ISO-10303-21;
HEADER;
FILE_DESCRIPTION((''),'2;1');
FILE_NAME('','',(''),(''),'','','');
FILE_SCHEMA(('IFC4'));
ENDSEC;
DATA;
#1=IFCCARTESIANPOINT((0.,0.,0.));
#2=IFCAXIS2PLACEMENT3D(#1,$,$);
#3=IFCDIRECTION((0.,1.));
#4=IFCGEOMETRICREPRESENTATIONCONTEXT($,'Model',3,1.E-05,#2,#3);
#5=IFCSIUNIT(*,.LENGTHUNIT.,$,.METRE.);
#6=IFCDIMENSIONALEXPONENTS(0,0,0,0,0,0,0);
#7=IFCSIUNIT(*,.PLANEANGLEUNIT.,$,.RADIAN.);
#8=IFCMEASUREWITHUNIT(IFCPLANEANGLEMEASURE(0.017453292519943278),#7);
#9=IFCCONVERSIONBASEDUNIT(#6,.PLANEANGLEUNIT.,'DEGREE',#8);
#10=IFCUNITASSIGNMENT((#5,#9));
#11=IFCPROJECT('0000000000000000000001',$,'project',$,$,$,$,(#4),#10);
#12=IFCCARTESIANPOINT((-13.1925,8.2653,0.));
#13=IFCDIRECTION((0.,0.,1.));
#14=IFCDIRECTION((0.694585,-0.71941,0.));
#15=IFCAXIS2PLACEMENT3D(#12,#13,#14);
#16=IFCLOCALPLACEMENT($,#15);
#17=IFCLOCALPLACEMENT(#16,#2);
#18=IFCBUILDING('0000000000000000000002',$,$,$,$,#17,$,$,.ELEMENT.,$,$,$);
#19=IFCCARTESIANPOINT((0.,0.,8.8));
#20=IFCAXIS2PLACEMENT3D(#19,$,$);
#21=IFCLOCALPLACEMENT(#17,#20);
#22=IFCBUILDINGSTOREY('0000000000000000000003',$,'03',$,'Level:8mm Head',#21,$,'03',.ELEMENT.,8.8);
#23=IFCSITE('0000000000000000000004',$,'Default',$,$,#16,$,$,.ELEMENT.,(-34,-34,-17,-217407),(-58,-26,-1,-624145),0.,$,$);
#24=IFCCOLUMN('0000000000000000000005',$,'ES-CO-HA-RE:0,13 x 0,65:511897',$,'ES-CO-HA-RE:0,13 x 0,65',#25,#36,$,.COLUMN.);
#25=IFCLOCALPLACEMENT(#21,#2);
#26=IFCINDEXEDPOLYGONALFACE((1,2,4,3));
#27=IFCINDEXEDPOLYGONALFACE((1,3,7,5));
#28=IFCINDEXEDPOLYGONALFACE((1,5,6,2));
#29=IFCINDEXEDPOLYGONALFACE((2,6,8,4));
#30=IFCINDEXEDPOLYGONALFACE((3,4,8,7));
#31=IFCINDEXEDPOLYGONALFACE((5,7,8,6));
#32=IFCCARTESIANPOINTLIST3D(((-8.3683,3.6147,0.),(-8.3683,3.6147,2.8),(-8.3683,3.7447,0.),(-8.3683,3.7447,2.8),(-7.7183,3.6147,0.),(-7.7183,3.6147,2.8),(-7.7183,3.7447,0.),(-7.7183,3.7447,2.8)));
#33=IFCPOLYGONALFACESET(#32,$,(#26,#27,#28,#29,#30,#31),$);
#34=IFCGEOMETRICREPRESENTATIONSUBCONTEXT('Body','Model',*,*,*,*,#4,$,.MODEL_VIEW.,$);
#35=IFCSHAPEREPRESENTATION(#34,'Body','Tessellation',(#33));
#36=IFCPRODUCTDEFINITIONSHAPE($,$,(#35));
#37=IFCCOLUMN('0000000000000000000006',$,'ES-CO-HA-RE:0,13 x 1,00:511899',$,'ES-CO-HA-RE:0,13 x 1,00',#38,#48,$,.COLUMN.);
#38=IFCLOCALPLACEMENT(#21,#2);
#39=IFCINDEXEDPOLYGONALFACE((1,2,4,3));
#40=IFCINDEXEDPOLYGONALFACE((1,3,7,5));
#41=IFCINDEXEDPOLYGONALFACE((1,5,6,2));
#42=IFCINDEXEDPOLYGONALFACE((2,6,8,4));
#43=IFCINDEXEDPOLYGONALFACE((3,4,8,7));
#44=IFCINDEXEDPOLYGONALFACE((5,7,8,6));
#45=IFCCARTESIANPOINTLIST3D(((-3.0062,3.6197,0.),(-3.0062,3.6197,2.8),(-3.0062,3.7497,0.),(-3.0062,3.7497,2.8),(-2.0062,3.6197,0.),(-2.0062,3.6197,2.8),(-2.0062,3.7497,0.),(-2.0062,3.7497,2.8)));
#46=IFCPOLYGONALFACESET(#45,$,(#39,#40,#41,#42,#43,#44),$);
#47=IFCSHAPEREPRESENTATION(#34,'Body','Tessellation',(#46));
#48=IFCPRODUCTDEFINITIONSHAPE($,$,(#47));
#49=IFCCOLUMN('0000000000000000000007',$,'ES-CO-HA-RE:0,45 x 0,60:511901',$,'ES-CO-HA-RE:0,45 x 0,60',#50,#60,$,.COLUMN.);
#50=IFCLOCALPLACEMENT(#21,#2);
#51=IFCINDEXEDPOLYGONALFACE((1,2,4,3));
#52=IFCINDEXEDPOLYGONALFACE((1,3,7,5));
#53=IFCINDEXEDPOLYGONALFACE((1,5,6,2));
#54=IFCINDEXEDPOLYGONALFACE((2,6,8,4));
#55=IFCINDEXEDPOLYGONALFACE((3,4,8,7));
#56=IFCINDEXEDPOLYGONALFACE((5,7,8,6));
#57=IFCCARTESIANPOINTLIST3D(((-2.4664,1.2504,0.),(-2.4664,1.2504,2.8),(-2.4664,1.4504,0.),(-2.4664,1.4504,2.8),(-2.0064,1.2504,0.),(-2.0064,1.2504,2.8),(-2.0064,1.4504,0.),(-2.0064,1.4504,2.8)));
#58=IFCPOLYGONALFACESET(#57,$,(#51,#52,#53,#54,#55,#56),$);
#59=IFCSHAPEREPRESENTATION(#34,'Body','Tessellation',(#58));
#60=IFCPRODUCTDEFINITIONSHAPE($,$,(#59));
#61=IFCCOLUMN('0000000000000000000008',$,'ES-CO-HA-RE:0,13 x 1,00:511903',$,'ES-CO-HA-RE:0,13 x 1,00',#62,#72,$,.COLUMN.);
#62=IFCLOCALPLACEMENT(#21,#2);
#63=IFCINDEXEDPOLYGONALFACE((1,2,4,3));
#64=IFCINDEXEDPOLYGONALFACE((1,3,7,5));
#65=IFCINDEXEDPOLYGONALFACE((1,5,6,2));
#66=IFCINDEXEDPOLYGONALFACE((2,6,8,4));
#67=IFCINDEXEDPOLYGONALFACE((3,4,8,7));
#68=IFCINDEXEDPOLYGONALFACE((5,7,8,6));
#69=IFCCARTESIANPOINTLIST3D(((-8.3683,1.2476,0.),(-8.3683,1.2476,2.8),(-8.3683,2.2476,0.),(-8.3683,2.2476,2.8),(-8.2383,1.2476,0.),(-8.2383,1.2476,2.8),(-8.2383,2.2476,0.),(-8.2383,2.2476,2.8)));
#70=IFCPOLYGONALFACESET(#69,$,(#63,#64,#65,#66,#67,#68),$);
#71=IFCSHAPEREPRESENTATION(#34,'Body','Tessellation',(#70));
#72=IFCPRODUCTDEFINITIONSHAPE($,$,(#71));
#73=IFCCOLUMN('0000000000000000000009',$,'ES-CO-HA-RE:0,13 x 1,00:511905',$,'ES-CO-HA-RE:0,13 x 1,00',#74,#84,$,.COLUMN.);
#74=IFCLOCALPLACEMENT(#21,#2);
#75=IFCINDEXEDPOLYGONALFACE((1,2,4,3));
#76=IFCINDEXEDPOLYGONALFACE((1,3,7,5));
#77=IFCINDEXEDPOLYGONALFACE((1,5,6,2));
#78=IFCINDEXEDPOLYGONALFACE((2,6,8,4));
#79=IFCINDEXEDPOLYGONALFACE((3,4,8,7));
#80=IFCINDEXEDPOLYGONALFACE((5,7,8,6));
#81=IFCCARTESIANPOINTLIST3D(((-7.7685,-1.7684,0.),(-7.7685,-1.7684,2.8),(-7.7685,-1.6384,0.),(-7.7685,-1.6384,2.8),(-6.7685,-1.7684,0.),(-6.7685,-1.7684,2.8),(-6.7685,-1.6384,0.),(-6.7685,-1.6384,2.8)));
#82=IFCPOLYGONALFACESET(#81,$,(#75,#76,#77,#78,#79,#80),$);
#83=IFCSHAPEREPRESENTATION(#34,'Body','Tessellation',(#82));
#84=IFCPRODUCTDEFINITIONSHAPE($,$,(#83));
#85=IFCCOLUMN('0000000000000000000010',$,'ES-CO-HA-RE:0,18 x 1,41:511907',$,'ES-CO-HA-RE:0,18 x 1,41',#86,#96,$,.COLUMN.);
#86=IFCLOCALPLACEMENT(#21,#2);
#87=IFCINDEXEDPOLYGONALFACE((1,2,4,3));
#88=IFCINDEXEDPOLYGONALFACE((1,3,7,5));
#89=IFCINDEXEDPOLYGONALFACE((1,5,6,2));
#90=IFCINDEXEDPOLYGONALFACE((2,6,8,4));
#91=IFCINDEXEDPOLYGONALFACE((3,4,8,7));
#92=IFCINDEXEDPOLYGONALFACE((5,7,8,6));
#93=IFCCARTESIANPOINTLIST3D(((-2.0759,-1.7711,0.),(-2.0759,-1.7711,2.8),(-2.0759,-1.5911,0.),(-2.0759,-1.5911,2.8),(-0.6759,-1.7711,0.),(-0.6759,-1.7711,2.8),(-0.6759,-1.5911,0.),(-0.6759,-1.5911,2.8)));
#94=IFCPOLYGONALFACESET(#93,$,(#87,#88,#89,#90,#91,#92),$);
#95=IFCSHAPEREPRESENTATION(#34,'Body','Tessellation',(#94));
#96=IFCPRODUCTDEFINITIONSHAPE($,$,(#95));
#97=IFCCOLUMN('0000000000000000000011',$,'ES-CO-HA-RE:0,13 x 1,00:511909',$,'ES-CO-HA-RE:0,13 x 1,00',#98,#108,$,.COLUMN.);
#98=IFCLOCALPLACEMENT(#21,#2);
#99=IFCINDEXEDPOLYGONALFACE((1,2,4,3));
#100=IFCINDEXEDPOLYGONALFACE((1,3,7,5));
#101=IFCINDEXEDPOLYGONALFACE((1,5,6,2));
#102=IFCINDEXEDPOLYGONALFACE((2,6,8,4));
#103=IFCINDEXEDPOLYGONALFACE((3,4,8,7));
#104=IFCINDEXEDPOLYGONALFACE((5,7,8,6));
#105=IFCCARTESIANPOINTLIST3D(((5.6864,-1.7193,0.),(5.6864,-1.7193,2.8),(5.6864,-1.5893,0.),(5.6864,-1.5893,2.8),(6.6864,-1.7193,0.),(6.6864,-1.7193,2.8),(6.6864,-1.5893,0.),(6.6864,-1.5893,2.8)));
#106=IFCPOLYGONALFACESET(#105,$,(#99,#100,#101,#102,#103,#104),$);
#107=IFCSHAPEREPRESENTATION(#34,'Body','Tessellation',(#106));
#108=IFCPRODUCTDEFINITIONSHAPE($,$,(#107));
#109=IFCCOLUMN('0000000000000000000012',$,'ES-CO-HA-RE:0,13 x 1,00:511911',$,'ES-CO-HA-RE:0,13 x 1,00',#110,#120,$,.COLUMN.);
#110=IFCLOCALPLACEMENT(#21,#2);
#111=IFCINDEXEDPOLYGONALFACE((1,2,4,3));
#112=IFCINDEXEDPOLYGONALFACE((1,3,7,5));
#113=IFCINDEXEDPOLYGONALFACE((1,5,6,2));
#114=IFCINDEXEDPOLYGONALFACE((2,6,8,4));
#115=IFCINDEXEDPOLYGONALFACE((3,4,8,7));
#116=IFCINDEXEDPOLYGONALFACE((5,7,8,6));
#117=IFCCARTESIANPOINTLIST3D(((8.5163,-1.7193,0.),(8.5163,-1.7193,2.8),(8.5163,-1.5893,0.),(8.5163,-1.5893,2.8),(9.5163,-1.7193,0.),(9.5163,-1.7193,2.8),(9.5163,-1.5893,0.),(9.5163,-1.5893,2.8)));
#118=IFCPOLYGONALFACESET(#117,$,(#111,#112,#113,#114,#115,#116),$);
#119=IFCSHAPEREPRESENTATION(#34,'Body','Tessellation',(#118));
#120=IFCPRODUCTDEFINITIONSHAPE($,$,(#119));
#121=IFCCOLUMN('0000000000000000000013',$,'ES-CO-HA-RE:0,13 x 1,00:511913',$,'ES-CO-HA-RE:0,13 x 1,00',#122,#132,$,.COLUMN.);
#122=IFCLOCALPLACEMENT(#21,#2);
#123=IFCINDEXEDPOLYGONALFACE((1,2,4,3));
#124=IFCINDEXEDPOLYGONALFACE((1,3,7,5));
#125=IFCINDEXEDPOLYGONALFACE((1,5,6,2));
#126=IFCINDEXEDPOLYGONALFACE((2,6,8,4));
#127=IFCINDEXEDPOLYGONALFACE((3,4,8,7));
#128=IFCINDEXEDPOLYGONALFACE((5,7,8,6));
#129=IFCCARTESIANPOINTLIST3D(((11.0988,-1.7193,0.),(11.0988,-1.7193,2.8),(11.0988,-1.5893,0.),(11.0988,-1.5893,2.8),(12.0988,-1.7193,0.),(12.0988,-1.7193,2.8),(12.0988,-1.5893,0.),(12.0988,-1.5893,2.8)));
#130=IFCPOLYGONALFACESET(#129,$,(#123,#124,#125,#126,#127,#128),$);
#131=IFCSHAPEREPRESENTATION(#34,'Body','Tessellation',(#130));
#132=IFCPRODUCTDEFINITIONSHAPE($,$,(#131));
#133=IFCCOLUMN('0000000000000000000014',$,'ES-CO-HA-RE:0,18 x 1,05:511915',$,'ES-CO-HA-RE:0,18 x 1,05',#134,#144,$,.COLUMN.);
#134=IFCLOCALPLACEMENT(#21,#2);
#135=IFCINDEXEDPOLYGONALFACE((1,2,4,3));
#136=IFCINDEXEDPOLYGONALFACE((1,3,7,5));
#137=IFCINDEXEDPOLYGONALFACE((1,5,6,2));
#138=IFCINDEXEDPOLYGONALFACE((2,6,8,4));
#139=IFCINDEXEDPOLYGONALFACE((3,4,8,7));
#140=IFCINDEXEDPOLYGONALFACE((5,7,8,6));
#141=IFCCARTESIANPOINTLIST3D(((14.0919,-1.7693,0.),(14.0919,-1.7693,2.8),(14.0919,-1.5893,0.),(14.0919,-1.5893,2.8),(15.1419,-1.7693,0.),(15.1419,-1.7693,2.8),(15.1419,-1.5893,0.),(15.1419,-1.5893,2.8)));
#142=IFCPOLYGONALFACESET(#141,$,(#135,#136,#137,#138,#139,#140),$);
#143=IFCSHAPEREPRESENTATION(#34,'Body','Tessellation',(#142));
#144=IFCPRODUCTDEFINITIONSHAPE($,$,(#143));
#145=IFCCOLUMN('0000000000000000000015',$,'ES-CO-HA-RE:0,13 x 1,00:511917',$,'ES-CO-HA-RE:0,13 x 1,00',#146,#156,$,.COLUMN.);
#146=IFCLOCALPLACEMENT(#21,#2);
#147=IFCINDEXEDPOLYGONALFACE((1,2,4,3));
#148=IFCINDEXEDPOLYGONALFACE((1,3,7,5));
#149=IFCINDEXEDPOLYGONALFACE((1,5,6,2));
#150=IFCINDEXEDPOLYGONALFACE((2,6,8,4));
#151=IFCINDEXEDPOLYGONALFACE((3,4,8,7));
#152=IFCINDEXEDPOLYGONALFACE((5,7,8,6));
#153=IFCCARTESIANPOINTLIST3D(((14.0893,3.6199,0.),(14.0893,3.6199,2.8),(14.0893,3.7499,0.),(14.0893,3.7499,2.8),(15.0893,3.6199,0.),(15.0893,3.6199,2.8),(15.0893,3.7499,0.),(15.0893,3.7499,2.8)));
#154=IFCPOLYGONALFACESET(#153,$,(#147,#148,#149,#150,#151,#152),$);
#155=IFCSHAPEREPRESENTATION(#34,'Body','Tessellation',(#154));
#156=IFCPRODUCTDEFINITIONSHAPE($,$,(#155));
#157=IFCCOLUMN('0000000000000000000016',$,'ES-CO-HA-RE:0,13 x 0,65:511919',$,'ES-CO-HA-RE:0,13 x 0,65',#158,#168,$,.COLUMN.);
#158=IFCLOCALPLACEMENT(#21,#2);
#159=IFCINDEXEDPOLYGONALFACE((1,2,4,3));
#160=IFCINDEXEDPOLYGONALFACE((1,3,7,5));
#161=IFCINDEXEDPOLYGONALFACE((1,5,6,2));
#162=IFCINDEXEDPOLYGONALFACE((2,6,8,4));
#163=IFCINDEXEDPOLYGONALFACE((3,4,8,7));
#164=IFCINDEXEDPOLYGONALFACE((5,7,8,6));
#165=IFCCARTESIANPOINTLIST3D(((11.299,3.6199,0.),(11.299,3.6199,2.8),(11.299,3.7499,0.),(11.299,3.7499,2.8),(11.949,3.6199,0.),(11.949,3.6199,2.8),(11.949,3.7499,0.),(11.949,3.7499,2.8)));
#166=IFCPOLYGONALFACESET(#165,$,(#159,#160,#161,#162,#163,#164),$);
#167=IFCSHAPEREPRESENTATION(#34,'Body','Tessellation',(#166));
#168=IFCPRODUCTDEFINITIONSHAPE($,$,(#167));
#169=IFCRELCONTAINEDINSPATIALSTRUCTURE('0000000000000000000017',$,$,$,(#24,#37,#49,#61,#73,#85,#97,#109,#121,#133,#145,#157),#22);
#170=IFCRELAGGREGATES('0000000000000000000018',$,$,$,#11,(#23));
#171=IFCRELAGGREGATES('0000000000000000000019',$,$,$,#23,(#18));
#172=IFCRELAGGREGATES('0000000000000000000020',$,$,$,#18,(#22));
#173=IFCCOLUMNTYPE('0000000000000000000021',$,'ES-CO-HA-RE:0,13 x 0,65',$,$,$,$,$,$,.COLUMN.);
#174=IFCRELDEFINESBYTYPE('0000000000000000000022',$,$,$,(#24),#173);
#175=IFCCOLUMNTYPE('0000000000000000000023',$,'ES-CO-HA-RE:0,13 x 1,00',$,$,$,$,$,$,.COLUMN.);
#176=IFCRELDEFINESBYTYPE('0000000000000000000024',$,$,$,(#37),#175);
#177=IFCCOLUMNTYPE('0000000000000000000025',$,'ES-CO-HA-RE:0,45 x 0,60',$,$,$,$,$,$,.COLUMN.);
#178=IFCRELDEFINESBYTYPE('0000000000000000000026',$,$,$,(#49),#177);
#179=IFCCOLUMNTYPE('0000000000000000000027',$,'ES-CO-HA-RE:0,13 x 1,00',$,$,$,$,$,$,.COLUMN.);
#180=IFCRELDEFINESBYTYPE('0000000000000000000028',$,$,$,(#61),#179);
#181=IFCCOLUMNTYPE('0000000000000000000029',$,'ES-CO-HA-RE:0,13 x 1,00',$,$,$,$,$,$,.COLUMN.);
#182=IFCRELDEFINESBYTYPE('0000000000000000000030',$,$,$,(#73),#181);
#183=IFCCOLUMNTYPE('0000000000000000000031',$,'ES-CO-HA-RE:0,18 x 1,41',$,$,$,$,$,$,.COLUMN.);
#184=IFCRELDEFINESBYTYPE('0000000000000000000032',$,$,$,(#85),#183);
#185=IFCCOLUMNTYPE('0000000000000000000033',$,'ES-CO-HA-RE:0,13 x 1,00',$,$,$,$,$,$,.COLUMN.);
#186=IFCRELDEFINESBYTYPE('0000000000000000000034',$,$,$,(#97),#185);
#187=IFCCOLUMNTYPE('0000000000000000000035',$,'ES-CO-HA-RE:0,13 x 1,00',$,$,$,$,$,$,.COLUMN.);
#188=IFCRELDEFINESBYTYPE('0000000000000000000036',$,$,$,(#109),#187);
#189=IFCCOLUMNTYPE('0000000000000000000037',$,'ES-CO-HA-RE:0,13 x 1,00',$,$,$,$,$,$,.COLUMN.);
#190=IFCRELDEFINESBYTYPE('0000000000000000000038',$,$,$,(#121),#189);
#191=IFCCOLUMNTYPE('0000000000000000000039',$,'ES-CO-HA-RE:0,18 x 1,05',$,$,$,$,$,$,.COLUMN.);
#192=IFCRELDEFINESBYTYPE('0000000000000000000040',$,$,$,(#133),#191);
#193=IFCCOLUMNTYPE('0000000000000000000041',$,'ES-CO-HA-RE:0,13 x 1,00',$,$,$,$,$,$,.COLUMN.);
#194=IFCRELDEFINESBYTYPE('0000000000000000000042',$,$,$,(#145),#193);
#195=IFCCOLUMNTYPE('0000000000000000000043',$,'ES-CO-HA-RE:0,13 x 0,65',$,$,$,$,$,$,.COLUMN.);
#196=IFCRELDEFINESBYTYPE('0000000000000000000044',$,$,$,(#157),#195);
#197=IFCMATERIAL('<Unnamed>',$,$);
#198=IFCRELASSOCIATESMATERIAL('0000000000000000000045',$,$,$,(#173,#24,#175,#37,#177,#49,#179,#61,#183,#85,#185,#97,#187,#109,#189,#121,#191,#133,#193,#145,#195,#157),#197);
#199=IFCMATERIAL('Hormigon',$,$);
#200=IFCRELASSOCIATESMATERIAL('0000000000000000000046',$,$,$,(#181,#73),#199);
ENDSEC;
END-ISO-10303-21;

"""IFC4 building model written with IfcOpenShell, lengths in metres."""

from ifc_helpers import new_model, entity, si_unit, converted_unit, direction, frame, origin, place, context, subcontext, project, spatial, indexed_curve, outline, extrude, source, transform, mapped, material, type_object, type_shapes, element, save


model = new_model("IFC4")

# Units and contexts
model_context = context("Model", 3, precision=1e-05, world=origin(), true_north=direction((0.0, 1.0)))
body_context = subcontext(model_context, "Body", "Model", "MODEL_VIEW")
ifc_project = project(units=[si_unit("LENGTHUNIT", "METRE"), converted_unit("PLANEANGLEUNIT", "DEGREE", entity("IfcPlaneAngleMeasure", 0.017453292519943278), si_unit("PLANEANGLEUNIT", "RADIAN"), dimensions=[0, 0, 0, 0, 0, 0, 0])], contexts=[model_context])

# Site, building, storey
site_placement = place(None, frame((-13.1925, 8.2653, 0.0), z_axis=(0.0, 0.0, 1.0), x_axis=(0.694585, -0.71941, 0.0)))
site = spatial("IfcSite", under=ifc_project, at=site_placement, Name="Default", CompositionType="ELEMENT", RefLatitude=(-34, -34, -17, -217407), RefLongitude=(-58, -26, -1, -624145), RefElevation=0.0)
building_placement = place(site_placement, origin())
building = spatial("IfcBuilding", under=site, at=building_placement, CompositionType="ELEMENT")
storey_placement = place(building_placement, frame((0.0, 0.0, 8.8)))
storey = spatial("IfcBuildingStorey", under=building, at=storey_placement, Name="03", ObjectType="Level:8mm Head", LongName="03", CompositionType="ELEMENT", Elevation=8.8)

# Columns
ifc_material_1 = material(Name="<Unnamed>")
column_type_1 = type_object("IfcColumnType", Name="ES-CO-HA-RE:0,13 x 0,65", PredefinedType="COLUMN", material=ifc_material_1)
shared_shape_1 = source(origin(), body_context, "Body", "SweptSolid", [
    extrude(outline(indexed_curve([(-0.325, -0.065), (0.325, -0.065), (0.325, 0.065), (-0.325, 0.065), (-0.325, -0.065)], self_intersect=False)), frame((-8.0433, 3.6797, 8.8), z_axis=(0.0, 0.0, 1.0), x_axis=(-1.0, 0.0, 0.0)), (0.0, 0.0, 1.0), 2.8),
])
type_shapes(column_type_1, [shared_shape_1])
column_1_placement = place(storey_placement, frame((0.0, 0.0, -8.8)))
element("IfcColumn", 1, at=column_1_placement, inside=storey, type_object=column_type_1, material=ifc_material_1, Name="ES-CO-HA-RE:0,13 x 0,65:511897", ObjectType="ES-CO-HA-RE:0,13 x 0,65", PredefinedType="COLUMN", context=body_context, shape_type="MappedRepresentation", body=[
    mapped(shared_shape_1, transform((0.0, 0.0, 0.0), scale=1.0)),
])
column_type_2 = type_object("IfcColumnType", Name="ES-CO-HA-RE:0,13 x 1,00", PredefinedType="COLUMN", material=ifc_material_1)
shared_shape_2 = source(origin(), body_context, "Body", "SweptSolid", [
    extrude(outline(indexed_curve([(-0.5, -0.065), (0.5, -0.065), (0.5, 0.065), (-0.5, 0.065), (-0.5, -0.065)], self_intersect=False)), frame((-2.5062, 3.6847, 8.8), z_axis=(0.0, 0.0, 1.0), x_axis=(-1.0, 0.0, 0.0)), (0.0, 0.0, 1.0), 2.8),
])
type_shapes(column_type_2, [shared_shape_2])
column_2_placement = place(storey_placement, frame((0.0, 0.0, -8.8)))
element("IfcColumn", 2, at=column_2_placement, inside=storey, type_object=column_type_2, material=ifc_material_1, Name="ES-CO-HA-RE:0,13 x 1,00:511899", ObjectType="ES-CO-HA-RE:0,13 x 1,00", PredefinedType="COLUMN", context=body_context, shape_type="MappedRepresentation", body=[
    mapped(shared_shape_2, transform((0.0, 0.0, 0.0), scale=1.0)),
])
column_type_3 = type_object("IfcColumnType", Name="ES-CO-HA-RE:0,45 x 0,60", PredefinedType="COLUMN", material=ifc_material_1)
shared_shape_3 = source(origin(), body_context, "Body", "SweptSolid", [
    extrude(outline(indexed_curve([(-0.23, -0.1), (0.23, -0.1), (0.23, 0.1), (-0.23, 0.1), (-0.23, -0.1)], self_intersect=False)), frame((-2.2364, 1.3504, 8.8), z_axis=(0.0, 0.0, 1.0), x_axis=(-1.0, 0.0, 0.0)), (0.0, 0.0, 1.0), 2.8),
])
type_shapes(column_type_3, [shared_shape_3])
column_3_placement = place(storey_placement, frame((0.0, 0.0, -8.8)))
element("IfcColumn", 3, at=column_3_placement, inside=storey, type_object=column_type_3, material=ifc_material_1, Name="ES-CO-HA-RE:0,45 x 0,60:511901", ObjectType="ES-CO-HA-RE:0,45 x 0,60", PredefinedType="COLUMN", context=body_context, shape_type="MappedRepresentation", body=[
    mapped(shared_shape_3, transform((0.0, 0.0, 0.0), scale=1.0)),
])
column_type_4 = type_object("IfcColumnType", Name="ES-CO-HA-RE:0,13 x 1,00", PredefinedType="COLUMN", material=ifc_material_1)
shared_shape_4 = source(origin(), body_context, "Body", "SweptSolid", [
    extrude(outline(indexed_curve([(-0.5, -0.065), (0.5, -0.065), (0.5, 0.065), (-0.5, 0.065), (-0.5, -0.065)], self_intersect=False)), frame((-8.3033, 1.7476, 8.8), z_axis=(0.0, 0.0, 1.0), x_axis=(0.0, -1.0, 0.0)), (0.0, 0.0, 1.0), 2.8),
])
type_shapes(column_type_4, [shared_shape_4])
column_4_placement = place(storey_placement, frame((0.0, 0.0, -8.8)))
element("IfcColumn", 4, at=column_4_placement, inside=storey, type_object=column_type_4, material=ifc_material_1, Name="ES-CO-HA-RE:0,13 x 1,00:511903", ObjectType="ES-CO-HA-RE:0,13 x 1,00", PredefinedType="COLUMN", context=body_context, shape_type="MappedRepresentation", body=[
    mapped(shared_shape_4, transform((0.0, 0.0, 0.0), scale=1.0)),
])
ifc_material_2 = material(Name="Hormigon")
column_type_5 = type_object("IfcColumnType", Name="ES-CO-HA-RE:0,13 x 1,00", PredefinedType="COLUMN", material=ifc_material_2)
shared_shape_5 = source(origin(), body_context, "Body", "SweptSolid", [
    extrude(outline(indexed_curve([(-0.5, -0.065), (0.5, -0.065), (0.5, 0.065), (-0.5, 0.065), (-0.5, -0.065)], self_intersect=False)), frame((-7.2685, -1.7034, 8.8), z_axis=(0.0, 0.0, 1.0), x_axis=(-1.0, 0.0, 0.0)), (0.0, 0.0, 1.0), 2.8),
])
type_shapes(column_type_5, [shared_shape_5])
column_5_placement = place(storey_placement, frame((0.0, 0.0, -8.8)))
element("IfcColumn", 5, at=column_5_placement, inside=storey, type_object=column_type_5, material=ifc_material_2, Name="ES-CO-HA-RE:0,13 x 1,00:511905", ObjectType="ES-CO-HA-RE:0,13 x 1,00", PredefinedType="COLUMN", context=body_context, shape_type="MappedRepresentation", body=[
    mapped(shared_shape_5, transform((0.0, 0.0, 0.0), scale=1.0)),
])
column_type_6 = type_object("IfcColumnType", Name="ES-CO-HA-RE:0,18 x 1,41", PredefinedType="COLUMN", material=ifc_material_1)
shared_shape_6 = source(origin(), body_context, "Body", "SweptSolid", [
    extrude(outline(indexed_curve([(-0.7, -0.09), (0.7, -0.09), (0.7, 0.09), (-0.7, 0.09), (-0.7, -0.09)], self_intersect=False)), frame((-1.3759, -1.6811, 8.8), z_axis=(0.0, 0.0, 1.0), x_axis=(-1.0, 0.0, 0.0)), (0.0, 0.0, 1.0), 2.8),
])
type_shapes(column_type_6, [shared_shape_6])
column_6_placement = place(storey_placement, frame((0.0, 0.0, -8.8)))
element("IfcColumn", 6, at=column_6_placement, inside=storey, type_object=column_type_6, material=ifc_material_1, Name="ES-CO-HA-RE:0,18 x 1,41:511907", ObjectType="ES-CO-HA-RE:0,18 x 1,41", PredefinedType="COLUMN", context=body_context, shape_type="MappedRepresentation", body=[
    mapped(shared_shape_6, transform((0.0, 0.0, 0.0), scale=1.0)),
])
column_type_7 = type_object("IfcColumnType", Name="ES-CO-HA-RE:0,13 x 1,00", PredefinedType="COLUMN", material=ifc_material_1)
shared_shape_7 = source(origin(), body_context, "Body", "SweptSolid", [
    extrude(outline(indexed_curve([(-0.5, -0.065), (0.5, -0.065), (0.5, 0.065), (-0.5, 0.065), (-0.5, -0.065)], self_intersect=False)), frame((6.1864, -1.6543, 8.8), z_axis=(0.0, 0.0, 1.0), x_axis=(-1.0, 0.0, 0.0)), (0.0, 0.0, 1.0), 2.8),
])
type_shapes(column_type_7, [shared_shape_7])
column_7_placement = place(storey_placement, frame((0.0, 0.0, -8.8)))
element("IfcColumn", 7, at=column_7_placement, inside=storey, type_object=column_type_7, material=ifc_material_1, Name="ES-CO-HA-RE:0,13 x 1,00:511909", ObjectType="ES-CO-HA-RE:0,13 x 1,00", PredefinedType="COLUMN", context=body_context, shape_type="MappedRepresentation", body=[
    mapped(shared_shape_7, transform((0.0, 0.0, 0.0), scale=1.0)),
])
column_type_8 = type_object("IfcColumnType", Name="ES-CO-HA-RE:0,13 x 1,00", PredefinedType="COLUMN", material=ifc_material_1)
shared_shape_8 = source(origin(), body_context, "Body", "SweptSolid", [
    extrude(outline(indexed_curve([(-0.5, -0.065), (0.5, -0.065), (0.5, 0.065), (-0.5, 0.065), (-0.5, -0.065)], self_intersect=False)), frame((9.0163, -1.6543, 8.8), z_axis=(0.0, 0.0, 1.0), x_axis=(-1.0, 0.0, 0.0)), (0.0, 0.0, 1.0), 2.8),
])
type_shapes(column_type_8, [shared_shape_8])
column_8_placement = place(storey_placement, frame((0.0, 0.0, -8.8)))
element("IfcColumn", 8, at=column_8_placement, inside=storey, type_object=column_type_8, material=ifc_material_1, Name="ES-CO-HA-RE:0,13 x 1,00:511911", ObjectType="ES-CO-HA-RE:0,13 x 1,00", PredefinedType="COLUMN", context=body_context, shape_type="MappedRepresentation", body=[
    mapped(shared_shape_8, transform((0.0, 0.0, 0.0), scale=1.0)),
])
column_type_9 = type_object("IfcColumnType", Name="ES-CO-HA-RE:0,13 x 1,00", PredefinedType="COLUMN", material=ifc_material_1)
shared_shape_9 = source(origin(), body_context, "Body", "SweptSolid", [
    extrude(outline(indexed_curve([(-0.5, -0.065), (0.5, -0.065), (0.5, 0.065), (-0.5, 0.065), (-0.5, -0.065)], self_intersect=False)), frame((11.5988, -1.6543, 8.8), z_axis=(0.0, 0.0, 1.0), x_axis=(-1.0, 0.0, 0.0)), (0.0, 0.0, 1.0), 2.8),
])
type_shapes(column_type_9, [shared_shape_9])
column_9_placement = place(storey_placement, frame((0.0, 0.0, -8.8)))
element("IfcColumn", 9, at=column_9_placement, inside=storey, type_object=column_type_9, material=ifc_material_1, Name="ES-CO-HA-RE:0,13 x 1,00:511913", ObjectType="ES-CO-HA-RE:0,13 x 1,00", PredefinedType="COLUMN", context=body_context, shape_type="MappedRepresentation", body=[
    mapped(shared_shape_9, transform((0.0, 0.0, 0.0), scale=1.0)),
])
column_type_10 = type_object("IfcColumnType", Name="ES-CO-HA-RE:0,18 x 1,05", PredefinedType="COLUMN", material=ifc_material_1)
shared_shape_10 = source(origin(), body_context, "Body", "SweptSolid", [
    extrude(outline(indexed_curve([(-0.525, -0.09), (0.525, -0.09), (0.525, 0.09), (-0.525, 0.09), (-0.525, -0.09)], self_intersect=False)), frame((14.6169, -1.6793, 8.8), z_axis=(0.0, 0.0, 1.0), x_axis=(-1.0, 0.0, 0.0)), (0.0, 0.0, 1.0), 2.8),
])
type_shapes(column_type_10, [shared_shape_10])
column_10_placement = place(storey_placement, frame((0.0, 0.0, -8.8)))
element("IfcColumn", 10, at=column_10_placement, inside=storey, type_object=column_type_10, material=ifc_material_1, Name="ES-CO-HA-RE:0,18 x 1,05:511915", ObjectType="ES-CO-HA-RE:0,18 x 1,05", PredefinedType="COLUMN", context=body_context, shape_type="MappedRepresentation", body=[
    mapped(shared_shape_10, transform((0.0, 0.0, 0.0), scale=1.0)),
])
column_type_11 = type_object("IfcColumnType", Name="ES-CO-HA-RE:0,13 x 1,00", PredefinedType="COLUMN", material=ifc_material_1)
shared_shape_11 = source(origin(), body_context, "Body", "SweptSolid", [
    extrude(outline(indexed_curve([(-0.5, -0.065), (0.5, -0.065), (0.5, 0.065), (-0.5, 0.065), (-0.5, -0.065)], self_intersect=False)), frame((14.5893, 3.6849, 8.8), z_axis=(0.0, 0.0, 1.0), x_axis=(-1.0, 0.0, 0.0)), (0.0, 0.0, 1.0), 2.8),
])
type_shapes(column_type_11, [shared_shape_11])
column_11_placement = place(storey_placement, frame((0.0, 0.0, -8.8)))
element("IfcColumn", 11, at=column_11_placement, inside=storey, type_object=column_type_11, material=ifc_material_1, Name="ES-CO-HA-RE:0,13 x 1,00:511917", ObjectType="ES-CO-HA-RE:0,13 x 1,00", PredefinedType="COLUMN", context=body_context, shape_type="MappedRepresentation", body=[
    mapped(shared_shape_11, transform((0.0, 0.0, 0.0), scale=1.0)),
])
column_type_12 = type_object("IfcColumnType", Name="ES-CO-HA-RE:0,13 x 0,65", PredefinedType="COLUMN", material=ifc_material_1)
shared_shape_12 = source(origin(), body_context, "Body", "SweptSolid", [
    extrude(outline(indexed_curve([(-0.325, -0.065), (0.325, -0.065), (0.325, 0.065), (-0.325, 0.065), (-0.325, -0.065)], self_intersect=False)), frame((11.624, 3.6849, 8.8), z_axis=(0.0, 0.0, 1.0), x_axis=(-1.0, 0.0, 0.0)), (0.0, 0.0, 1.0), 2.8),
])
type_shapes(column_type_12, [shared_shape_12])
column_12_placement = place(storey_placement, frame((0.0, 0.0, -8.8)))
element("IfcColumn", 12, at=column_12_placement, inside=storey, type_object=column_type_12, material=ifc_material_1, Name="ES-CO-HA-RE:0,13 x 0,65:511919", ObjectType="ES-CO-HA-RE:0,13 x 0,65", PredefinedType="COLUMN", context=body_context, shape_type="MappedRepresentation", body=[
    mapped(shared_shape_12, transform((0.0, 0.0, 0.0), scale=1.0)),
])

save(model, "model.ifc")
